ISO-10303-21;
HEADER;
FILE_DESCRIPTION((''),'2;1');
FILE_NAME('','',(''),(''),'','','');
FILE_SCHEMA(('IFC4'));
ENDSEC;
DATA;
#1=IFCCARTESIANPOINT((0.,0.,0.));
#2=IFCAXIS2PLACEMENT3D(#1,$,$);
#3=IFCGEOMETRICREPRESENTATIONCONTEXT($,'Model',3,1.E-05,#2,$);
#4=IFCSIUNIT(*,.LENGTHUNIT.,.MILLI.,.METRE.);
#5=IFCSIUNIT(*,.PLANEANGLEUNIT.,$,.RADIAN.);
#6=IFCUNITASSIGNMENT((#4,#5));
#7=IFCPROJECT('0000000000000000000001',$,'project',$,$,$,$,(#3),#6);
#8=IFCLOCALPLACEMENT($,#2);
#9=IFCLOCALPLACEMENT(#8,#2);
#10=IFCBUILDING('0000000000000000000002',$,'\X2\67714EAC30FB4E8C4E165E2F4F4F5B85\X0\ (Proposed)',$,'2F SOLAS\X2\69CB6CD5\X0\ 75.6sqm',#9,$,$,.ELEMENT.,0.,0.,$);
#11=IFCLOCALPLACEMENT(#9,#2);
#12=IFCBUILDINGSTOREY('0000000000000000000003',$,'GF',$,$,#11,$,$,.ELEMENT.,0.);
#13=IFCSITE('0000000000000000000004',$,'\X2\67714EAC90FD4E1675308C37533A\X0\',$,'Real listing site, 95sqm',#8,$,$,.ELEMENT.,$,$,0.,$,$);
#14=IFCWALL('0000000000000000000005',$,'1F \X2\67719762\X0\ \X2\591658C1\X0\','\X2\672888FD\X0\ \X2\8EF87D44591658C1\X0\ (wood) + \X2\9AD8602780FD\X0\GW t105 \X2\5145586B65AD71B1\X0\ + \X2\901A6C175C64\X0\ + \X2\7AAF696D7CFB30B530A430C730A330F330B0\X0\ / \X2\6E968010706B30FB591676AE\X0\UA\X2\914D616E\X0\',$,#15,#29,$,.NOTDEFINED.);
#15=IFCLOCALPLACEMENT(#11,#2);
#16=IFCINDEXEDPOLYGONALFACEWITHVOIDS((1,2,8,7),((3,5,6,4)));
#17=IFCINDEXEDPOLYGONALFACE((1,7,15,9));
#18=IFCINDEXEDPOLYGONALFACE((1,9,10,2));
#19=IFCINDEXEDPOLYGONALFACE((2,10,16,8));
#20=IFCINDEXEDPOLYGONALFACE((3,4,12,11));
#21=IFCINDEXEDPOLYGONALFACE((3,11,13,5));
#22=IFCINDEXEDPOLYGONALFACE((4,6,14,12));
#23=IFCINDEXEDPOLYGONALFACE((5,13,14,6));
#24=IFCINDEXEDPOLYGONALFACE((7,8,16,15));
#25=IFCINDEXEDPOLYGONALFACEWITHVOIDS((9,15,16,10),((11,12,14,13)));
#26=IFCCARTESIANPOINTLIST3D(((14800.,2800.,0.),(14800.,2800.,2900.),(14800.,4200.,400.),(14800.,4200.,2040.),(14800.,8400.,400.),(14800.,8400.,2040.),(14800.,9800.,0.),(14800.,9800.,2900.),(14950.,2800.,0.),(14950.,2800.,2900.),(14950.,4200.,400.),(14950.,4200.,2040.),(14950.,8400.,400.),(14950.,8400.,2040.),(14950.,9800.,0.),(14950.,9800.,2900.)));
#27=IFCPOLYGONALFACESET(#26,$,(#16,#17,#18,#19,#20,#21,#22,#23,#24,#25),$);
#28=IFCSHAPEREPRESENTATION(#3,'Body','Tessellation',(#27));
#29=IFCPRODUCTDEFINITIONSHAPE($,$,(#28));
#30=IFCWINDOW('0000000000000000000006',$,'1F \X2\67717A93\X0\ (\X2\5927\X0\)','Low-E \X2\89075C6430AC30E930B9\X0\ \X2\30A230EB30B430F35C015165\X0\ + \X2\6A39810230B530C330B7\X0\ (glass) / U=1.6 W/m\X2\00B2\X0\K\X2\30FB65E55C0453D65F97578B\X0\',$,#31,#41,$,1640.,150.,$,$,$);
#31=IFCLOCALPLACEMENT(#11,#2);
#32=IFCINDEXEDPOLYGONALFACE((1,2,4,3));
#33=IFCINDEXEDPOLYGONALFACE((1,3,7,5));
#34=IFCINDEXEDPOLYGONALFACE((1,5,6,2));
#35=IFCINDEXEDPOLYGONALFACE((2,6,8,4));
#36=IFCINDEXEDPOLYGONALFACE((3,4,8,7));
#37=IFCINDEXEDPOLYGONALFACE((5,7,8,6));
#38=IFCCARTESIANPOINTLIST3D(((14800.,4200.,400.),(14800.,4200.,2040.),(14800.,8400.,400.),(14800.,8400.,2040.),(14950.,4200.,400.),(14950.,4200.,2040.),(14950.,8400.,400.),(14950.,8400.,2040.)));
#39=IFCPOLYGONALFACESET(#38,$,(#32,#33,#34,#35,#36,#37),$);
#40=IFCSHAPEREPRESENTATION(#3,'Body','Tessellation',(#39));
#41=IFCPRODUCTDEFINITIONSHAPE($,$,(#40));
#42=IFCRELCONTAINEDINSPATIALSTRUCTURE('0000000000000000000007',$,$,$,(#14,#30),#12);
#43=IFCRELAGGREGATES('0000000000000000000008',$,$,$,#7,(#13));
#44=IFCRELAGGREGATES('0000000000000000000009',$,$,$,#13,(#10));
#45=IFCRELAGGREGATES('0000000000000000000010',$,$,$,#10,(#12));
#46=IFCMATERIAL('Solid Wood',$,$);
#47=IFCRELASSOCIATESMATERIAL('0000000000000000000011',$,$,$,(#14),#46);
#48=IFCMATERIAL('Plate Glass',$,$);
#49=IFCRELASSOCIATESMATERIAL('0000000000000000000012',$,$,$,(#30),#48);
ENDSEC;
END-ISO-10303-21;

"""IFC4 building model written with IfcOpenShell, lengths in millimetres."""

from ifc_helpers import new_model, si_unit, frame, frame_2d, origin, place, context, project, spatial, rectangle, extrude, material, element, fill, save


model = new_model("IFC4")

# Units and contexts
model_context = context("Model", 3, precision=1e-05, world=origin())
ifc_project = project(units=[si_unit("LENGTHUNIT", "METRE", prefix="MILLI"), si_unit("PLANEANGLEUNIT", "RADIAN")], contexts=[model_context])

# Site, building, storey
site_placement = place(None, origin())
site = spatial("IfcSite", under=ifc_project, at=site_placement, Name="東京都世田谷区", ObjectType="Real listing site, 95sqm", CompositionType="ELEMENT", RefElevation=0.0)
building_placement = place(site_placement, origin())
building = spatial("IfcBuilding", under=site, at=building_placement, Name="東京・二世帯住宅 (Proposed)", ObjectType="2F SOLAS構法 75.6sqm", CompositionType="ELEMENT", ElevationOfRefHeight=0.0, ElevationOfTerrain=0.0)
storey_placement = place(building_placement, origin())
storey = spatial("IfcBuildingStorey", under=building, at=storey_placement, Name="GF", CompositionType="ELEMENT", Elevation=0.0)

# Shared definitions
ifc_material_1 = material(Name="Solid Wood")

# Shared definitions
ifc_material_2 = material(Name="Plate Glass")

# Wall, opening, window
wall_1_placement = place(storey_placement, frame((7400.0, 1400.0, 0.0)))
wall_1 = element("IfcWall", 1, at=wall_1_placement, inside=storey, material=ifc_material_1, Name="1F 東面 外壁", Description="木製 軸組外壁 (wood) + 高性能GW t105 充填断熱 + 通気層 + 窯業系サイディング / 準耐火・外皮UA配慮", PredefinedType="NOTDEFINED", context=model_context, shape_type="SweptSolid", body=[
    extrude(rectangle(XDim=150.0, YDim=7000.0, at=frame_2d((75.0, 3500.0))), frame((7400.0, 1400.0, 0.0)), (0.0, 0.0, 1.0), 2900.0),
])
opening_1_placement = place(storey_placement, frame((7400.0, 2100.0, 200.0)))
opening_1 = element("IfcOpeningElement", 2, at=opening_1_placement, cuts=wall_1, PredefinedType="NOTDEFINED", context=model_context, shape_type="SweptSolid", body=[
    extrude(rectangle(XDim=150.0, YDim=4200.0, at=frame_2d((75.0, 2100.0))), frame((7400.0, 2100.0, 200.0)), (0.0, 0.0, 1.0), 1640.0),
])
window_1_placement = place(storey_placement, frame((7400.0, 2100.0, 200.0)))
window_1 = element("IfcWindow", 3, at=window_1_placement, inside=storey, material=ifc_material_2, Name="1F 東窓 (大)", Description="Low-E 複層ガラス アルゴン封入 + 樹脂サッシ (glass) / U=1.6 W/m²K・日射取得型", OverallHeight=1640.0, OverallWidth=150.0, context=model_context, shape_type="SweptSolid", body=[
    extrude(rectangle(XDim=150.0, YDim=4200.0, at=frame_2d((75.0, 2100.0))), frame((7400.0, 2100.0, 200.0)), (0.0, 0.0, 1.0), 1640.0),
])
fill(opening_1, window_1)

save(model, "model.ifc")
